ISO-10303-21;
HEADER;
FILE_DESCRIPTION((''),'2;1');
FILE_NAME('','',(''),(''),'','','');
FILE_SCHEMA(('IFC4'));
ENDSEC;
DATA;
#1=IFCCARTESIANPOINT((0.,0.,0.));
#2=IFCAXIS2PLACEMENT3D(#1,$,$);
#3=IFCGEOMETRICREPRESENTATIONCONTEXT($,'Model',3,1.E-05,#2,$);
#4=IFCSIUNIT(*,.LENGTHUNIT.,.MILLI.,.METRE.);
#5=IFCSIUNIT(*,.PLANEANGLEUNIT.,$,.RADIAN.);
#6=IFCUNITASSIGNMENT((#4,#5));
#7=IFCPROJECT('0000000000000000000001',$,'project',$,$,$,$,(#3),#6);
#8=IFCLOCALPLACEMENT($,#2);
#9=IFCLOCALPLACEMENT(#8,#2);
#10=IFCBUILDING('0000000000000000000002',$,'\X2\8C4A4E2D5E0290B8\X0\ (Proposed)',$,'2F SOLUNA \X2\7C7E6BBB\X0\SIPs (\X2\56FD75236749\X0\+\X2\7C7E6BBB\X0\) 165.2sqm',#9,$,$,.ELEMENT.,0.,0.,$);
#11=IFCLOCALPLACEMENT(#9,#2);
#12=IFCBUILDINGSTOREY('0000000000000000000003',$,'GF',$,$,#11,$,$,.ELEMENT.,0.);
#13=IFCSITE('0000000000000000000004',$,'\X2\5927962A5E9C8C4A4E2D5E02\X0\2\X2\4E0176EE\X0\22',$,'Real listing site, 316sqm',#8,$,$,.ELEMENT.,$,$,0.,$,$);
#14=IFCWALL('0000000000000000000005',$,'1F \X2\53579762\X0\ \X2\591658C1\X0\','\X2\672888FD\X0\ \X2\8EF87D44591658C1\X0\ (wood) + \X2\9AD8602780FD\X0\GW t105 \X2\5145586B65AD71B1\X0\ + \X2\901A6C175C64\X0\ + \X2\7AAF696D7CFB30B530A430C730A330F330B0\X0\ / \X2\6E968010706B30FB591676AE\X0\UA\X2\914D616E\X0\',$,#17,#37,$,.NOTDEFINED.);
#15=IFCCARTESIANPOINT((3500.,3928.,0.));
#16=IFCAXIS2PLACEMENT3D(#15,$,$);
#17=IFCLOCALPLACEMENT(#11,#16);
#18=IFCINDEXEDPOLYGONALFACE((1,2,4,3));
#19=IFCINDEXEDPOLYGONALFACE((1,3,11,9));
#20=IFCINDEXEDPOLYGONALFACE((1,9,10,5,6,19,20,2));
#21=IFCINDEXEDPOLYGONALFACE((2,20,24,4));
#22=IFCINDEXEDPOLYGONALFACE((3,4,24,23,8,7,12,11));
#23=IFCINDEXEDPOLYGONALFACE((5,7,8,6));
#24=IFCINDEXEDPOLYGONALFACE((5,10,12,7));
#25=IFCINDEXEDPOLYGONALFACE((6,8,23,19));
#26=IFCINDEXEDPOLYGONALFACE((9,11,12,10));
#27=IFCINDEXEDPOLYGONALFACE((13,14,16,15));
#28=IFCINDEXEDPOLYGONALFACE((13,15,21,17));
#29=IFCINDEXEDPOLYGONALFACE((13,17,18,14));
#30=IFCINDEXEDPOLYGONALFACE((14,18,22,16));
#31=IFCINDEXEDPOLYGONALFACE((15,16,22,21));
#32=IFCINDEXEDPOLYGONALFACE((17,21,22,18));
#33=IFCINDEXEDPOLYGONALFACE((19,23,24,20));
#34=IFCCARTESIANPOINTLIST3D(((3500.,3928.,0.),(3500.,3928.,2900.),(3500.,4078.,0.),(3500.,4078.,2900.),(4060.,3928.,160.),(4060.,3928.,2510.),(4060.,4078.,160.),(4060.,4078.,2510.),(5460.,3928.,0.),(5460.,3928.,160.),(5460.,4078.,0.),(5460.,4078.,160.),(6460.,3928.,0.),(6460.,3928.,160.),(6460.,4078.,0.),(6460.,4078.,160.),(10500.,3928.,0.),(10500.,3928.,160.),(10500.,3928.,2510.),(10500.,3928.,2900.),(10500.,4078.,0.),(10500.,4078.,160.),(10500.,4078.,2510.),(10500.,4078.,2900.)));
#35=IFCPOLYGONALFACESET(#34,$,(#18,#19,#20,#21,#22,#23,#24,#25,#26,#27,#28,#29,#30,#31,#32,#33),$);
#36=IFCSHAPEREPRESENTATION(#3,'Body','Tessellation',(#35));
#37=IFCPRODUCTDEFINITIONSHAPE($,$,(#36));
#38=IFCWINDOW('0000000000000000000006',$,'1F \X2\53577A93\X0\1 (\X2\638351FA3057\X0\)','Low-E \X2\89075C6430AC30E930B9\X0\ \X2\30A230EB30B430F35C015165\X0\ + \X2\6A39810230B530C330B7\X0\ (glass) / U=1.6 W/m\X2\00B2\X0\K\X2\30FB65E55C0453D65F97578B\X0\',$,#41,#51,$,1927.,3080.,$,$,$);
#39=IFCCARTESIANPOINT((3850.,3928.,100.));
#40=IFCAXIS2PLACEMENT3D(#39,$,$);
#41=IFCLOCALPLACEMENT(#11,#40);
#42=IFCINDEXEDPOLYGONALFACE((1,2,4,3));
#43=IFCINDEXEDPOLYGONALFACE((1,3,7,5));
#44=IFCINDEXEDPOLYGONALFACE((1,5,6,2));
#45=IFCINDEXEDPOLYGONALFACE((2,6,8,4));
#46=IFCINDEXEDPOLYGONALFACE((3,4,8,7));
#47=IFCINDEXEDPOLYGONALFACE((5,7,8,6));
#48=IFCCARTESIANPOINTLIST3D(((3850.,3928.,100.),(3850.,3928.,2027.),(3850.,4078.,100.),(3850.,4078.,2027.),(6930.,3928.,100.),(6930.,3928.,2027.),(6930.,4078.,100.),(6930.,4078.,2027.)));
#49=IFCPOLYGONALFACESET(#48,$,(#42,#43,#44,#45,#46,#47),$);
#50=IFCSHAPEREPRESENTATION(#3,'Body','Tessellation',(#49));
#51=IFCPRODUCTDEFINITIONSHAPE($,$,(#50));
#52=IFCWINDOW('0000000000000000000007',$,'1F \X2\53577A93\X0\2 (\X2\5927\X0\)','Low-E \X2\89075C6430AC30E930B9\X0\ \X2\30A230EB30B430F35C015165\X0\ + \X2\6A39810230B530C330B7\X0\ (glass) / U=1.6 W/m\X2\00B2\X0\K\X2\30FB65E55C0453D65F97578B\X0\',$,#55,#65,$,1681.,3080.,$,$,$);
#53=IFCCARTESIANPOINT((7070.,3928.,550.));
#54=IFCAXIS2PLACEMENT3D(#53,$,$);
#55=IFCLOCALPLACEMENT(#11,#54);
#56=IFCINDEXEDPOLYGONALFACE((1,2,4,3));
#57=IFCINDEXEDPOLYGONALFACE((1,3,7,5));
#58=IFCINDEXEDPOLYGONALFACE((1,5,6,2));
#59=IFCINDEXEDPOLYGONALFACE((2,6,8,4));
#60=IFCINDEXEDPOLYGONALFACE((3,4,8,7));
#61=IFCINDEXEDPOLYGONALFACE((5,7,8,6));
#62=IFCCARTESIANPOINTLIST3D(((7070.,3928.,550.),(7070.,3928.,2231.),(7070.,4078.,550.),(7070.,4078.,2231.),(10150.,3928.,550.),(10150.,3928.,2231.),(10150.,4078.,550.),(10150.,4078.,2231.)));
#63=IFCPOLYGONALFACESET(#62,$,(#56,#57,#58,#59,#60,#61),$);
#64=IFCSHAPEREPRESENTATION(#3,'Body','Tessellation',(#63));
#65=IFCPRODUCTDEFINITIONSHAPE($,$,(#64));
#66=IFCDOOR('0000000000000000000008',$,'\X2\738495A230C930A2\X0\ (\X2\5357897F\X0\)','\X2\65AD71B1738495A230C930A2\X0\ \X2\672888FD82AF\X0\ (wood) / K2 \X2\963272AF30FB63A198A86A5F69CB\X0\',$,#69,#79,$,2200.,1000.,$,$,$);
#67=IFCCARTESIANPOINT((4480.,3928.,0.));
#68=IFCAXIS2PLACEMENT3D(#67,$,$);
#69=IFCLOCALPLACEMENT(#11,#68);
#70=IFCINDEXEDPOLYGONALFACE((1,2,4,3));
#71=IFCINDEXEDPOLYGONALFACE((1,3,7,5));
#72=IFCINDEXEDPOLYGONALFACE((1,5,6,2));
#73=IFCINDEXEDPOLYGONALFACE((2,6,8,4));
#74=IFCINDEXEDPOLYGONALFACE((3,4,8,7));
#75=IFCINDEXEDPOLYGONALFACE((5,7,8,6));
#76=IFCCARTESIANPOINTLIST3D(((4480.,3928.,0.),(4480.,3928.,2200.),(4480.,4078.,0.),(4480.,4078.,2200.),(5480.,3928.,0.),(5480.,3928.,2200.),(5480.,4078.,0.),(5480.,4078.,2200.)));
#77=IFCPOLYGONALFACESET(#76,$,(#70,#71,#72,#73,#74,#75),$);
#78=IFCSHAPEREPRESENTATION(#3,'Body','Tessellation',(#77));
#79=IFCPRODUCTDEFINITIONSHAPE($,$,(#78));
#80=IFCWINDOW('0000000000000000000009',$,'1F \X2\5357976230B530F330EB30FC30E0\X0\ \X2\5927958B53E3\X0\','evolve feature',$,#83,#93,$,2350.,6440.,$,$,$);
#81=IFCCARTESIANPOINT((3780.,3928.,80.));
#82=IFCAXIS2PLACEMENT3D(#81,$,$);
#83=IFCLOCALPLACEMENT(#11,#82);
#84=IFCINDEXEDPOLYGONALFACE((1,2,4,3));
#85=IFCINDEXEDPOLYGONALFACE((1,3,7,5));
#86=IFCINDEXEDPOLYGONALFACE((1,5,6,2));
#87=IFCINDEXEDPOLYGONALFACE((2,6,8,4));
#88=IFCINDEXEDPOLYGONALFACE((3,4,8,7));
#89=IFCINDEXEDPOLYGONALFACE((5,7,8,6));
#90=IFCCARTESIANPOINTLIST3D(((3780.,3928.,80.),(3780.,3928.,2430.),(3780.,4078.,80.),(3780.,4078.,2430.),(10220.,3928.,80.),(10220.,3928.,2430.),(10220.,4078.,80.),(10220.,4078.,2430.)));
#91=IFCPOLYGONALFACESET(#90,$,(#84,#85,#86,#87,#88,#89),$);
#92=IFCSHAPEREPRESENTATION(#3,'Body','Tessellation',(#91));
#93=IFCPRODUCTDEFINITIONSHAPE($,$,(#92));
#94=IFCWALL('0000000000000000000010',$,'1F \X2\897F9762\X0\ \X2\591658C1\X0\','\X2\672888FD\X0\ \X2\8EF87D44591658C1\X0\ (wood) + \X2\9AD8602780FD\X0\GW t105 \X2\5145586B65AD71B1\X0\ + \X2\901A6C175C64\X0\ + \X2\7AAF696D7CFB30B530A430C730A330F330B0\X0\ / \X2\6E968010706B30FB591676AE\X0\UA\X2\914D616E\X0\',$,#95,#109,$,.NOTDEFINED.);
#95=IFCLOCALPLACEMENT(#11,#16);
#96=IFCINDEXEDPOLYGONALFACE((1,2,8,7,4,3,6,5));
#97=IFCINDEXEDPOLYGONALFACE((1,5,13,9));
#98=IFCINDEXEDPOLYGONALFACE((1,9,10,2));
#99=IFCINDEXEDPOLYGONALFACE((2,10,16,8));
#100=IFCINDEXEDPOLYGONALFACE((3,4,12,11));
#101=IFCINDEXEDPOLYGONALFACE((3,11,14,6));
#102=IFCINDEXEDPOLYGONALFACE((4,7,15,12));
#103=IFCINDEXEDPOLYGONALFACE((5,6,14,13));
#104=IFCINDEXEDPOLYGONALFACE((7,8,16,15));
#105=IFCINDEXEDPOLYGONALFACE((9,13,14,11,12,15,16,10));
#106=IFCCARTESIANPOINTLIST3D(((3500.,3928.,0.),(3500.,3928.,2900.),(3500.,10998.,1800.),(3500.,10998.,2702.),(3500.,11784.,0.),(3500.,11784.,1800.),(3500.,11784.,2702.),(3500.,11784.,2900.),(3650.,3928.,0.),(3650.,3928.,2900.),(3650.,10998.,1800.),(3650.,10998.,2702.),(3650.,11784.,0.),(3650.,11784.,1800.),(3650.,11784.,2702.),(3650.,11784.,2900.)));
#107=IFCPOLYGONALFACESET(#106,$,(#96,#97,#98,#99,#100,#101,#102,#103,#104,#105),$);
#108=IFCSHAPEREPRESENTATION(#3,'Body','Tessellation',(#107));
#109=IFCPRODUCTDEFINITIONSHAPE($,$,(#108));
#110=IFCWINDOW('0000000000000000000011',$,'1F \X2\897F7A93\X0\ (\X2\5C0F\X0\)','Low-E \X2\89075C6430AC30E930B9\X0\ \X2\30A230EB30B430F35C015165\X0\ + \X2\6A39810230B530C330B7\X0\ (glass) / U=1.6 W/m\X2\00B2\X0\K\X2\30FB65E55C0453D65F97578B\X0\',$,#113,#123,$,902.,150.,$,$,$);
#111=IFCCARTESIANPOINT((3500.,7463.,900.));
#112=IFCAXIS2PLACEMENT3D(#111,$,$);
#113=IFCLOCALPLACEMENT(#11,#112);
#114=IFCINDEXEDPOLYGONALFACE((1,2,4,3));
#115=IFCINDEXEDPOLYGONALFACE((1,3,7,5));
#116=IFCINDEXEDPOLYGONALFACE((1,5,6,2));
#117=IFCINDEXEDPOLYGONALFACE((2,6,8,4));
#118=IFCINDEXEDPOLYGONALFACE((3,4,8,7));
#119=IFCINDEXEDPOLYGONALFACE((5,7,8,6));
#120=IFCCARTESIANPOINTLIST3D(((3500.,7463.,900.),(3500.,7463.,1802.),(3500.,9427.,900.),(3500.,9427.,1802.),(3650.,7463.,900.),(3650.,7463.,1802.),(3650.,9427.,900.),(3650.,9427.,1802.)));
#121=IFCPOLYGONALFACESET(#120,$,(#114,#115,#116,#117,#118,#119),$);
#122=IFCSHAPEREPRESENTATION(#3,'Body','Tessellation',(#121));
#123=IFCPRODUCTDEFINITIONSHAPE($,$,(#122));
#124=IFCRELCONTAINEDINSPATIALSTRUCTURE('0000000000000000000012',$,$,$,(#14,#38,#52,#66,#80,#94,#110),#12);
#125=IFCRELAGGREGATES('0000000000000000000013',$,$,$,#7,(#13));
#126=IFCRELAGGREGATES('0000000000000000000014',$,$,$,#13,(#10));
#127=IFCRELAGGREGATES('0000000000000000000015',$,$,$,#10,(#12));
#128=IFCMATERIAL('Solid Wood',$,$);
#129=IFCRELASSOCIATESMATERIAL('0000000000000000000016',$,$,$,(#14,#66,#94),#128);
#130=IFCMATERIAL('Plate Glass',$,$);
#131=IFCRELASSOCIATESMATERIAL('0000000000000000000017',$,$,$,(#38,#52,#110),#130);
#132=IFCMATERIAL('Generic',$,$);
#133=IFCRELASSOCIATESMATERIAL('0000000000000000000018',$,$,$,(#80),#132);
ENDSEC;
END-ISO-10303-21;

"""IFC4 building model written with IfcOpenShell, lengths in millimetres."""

from ifc_helpers import new_model, si_unit, frame, frame_2d, origin, place, context, project, spatial, rectangle, extrude, material, element, fill, save


model = new_model("IFC4")

# Units and contexts
model_context = context("Model", 3, precision=1e-05, world=origin())
ifc_project = project(units=[si_unit("LENGTHUNIT", "METRE", prefix="MILLI"), si_unit("PLANEANGLEUNIT", "RADIAN")], contexts=[model_context])

# Site, building, storey
site_placement = place(None, origin())
site = spatial("IfcSite", under=ifc_project, at=site_placement, Name="大阪府豊中市2丁目22", ObjectType="Real listing site, 316sqm", CompositionType="ELEMENT", RefElevation=0.0)
building_placement = place(site_placement, origin())
building = spatial("IfcBuilding", under=site, at=building_placement, Name="豊中市邸 (Proposed)", ObjectType="2F SOLUNA 籾殻SIPs (国産杉+籾殻) 165.2sqm", CompositionType="ELEMENT", ElevationOfRefHeight=0.0, ElevationOfTerrain=0.0)
storey_placement = place(building_placement, origin())
storey = spatial("IfcBuildingStorey", under=building, at=storey_placement, Name="GF", CompositionType="ELEMENT", Elevation=0.0)

# Shared definitions
ifc_material_1 = material(Name="Solid Wood")
ifc_material_2 = material(Name="Generic")

# Wall, openings, windows, door
wall_1_placement = place(storey_placement, frame((3500.0, 3928.0, 0.0)))
wall_1 = element("IfcWall", 1, at=wall_1_placement, inside=storey, material=ifc_material_1, Name="1F 南面 外壁", Description="木製 軸組外壁 (wood) + 高性能GW t105 充填断熱 + 通気層 + 窯業系サイディング / 準耐火・外皮UA配慮", PredefinedType="NOTDEFINED", context=model_context, shape_type="SweptSolid", body=[
    extrude(rectangle(XDim=7000.0, YDim=150.0, at=frame_2d((3500.0, 75.0))), frame((3500.0, 3928.0, 0.0)), (0.0, 0.0, 1.0), 2900.0),
])
opening_1_placement = place(storey_placement, frame((3850.0, 3928.0, 100.0)))
opening_1 = element("IfcOpeningElement", 2, at=opening_1_placement, cuts=wall_1, PredefinedType="NOTDEFINED", context=model_context, shape_type="SweptSolid", body=[
    extrude(rectangle(XDim=3080.0, YDim=150.0, at=frame_2d((1540.0, 75.0))), frame((3850.0, 3928.0, 100.0)), (0.0, 0.0, 1.0), 1927.0),
])
opening_2_placement = place(storey_placement, frame((7070.0, 3928.0, 550.0)))
opening_2 = element("IfcOpeningElement", 3, at=opening_2_placement, cuts=wall_1, PredefinedType="NOTDEFINED", context=model_context, shape_type="SweptSolid", body=[
    extrude(rectangle(XDim=3080.0, YDim=150.0, at=frame_2d((1540.0, 75.0))), frame((7070.0, 3928.0, 550.0)), (0.0, 0.0, 1.0), 1681.0),
])
opening_3_placement = place(storey_placement, frame((4480.0, 3928.0, 0.0)))
opening_3 = element("IfcOpeningElement", 4, at=opening_3_placement, cuts=wall_1, PredefinedType="NOTDEFINED", context=model_context, shape_type="SweptSolid", body=[
    extrude(rectangle(XDim=1000.0, YDim=150.0, at=frame_2d((500.0, 75.0))), frame((4480.0, 3928.0, 0.0)), (0.0, 0.0, 1.0), 2200.0),
])
opening_4_placement = place(storey_placement, frame((3780.0, 3928.0, 80.0)))
opening_4 = element("IfcOpeningElement", 5, at=opening_4_placement, cuts=wall_1, PredefinedType="NOTDEFINED", context=model_context, shape_type="SweptSolid", body=[
    extrude(rectangle(XDim=6440.0, YDim=150.0, at=frame_2d((3220.0, 75.0))), frame((3780.0, 3928.0, 80.0)), (0.0, 0.0, 1.0), 2350.0),
])
ifc_material_3 = material(Name="Plate Glass")
window_1_placement = place(storey_placement, frame((3850.0, 3928.0, 100.0)))
window_1 = element("IfcWindow", 6, at=window_1_placement, inside=storey, material=ifc_material_3, Name="1F 南窓1 (掃出し)", Description="Low-E 複層ガラス アルゴン封入 + 樹脂サッシ (glass) / U=1.6 W/m²K・日射取得型", OverallHeight=1927.0, OverallWidth=3080.0, context=model_context, shape_type="SweptSolid", body=[
    extrude(rectangle(XDim=3080.0, YDim=150.0, at=frame_2d((1540.0, 75.0))), frame((3850.0, 3928.0, 100.0)), (0.0, 0.0, 1.0), 1927.0),
])
fill(opening_1, window_1)
window_2_placement = place(storey_placement, frame((7070.0, 3928.0, 550.0)))
window_2 = element("IfcWindow", 7, at=window_2_placement, inside=storey, material=ifc_material_3, Name="1F 南窓2 (大)", Description="Low-E 複層ガラス アルゴン封入 + 樹脂サッシ (glass) / U=1.6 W/m²K・日射取得型", OverallHeight=1681.0, OverallWidth=3080.0, context=model_context, shape_type="SweptSolid", body=[
    extrude(rectangle(XDim=3080.0, YDim=150.0, at=frame_2d((1540.0, 75.0))), frame((7070.0, 3928.0, 550.0)), (0.0, 0.0, 1.0), 1681.0),
])
fill(opening_2, window_2)
door_placement = place(storey_placement, frame((4480.0, 3928.0, 0.0)))
door = element("IfcDoor", 8, at=door_placement, inside=storey, material=ifc_material_1, Name="玄関ドア (南西)", Description="断熱玄関ドア 木製芯 (wood) / K2 防犯・採風機構", OverallHeight=2200.0, OverallWidth=1000.0, context=model_context, shape_type="SweptSolid", body=[
    extrude(rectangle(XDim=1000.0, YDim=150.0, at=frame_2d((500.0, 75.0))), frame((4480.0, 3928.0, 0.0)), (0.0, 0.0, 1.0), 2200.0),
])
fill(opening_3, door)
window_3_placement = place(storey_placement, frame((3780.0, 3928.0, 80.0)))
window_3 = element("IfcWindow", 9, at=window_3_placement, inside=storey, material=ifc_material_2, Name="1F 南面サンルーム 大開口", Description="evolve feature", OverallHeight=2350.0, OverallWidth=6440.0, context=model_context, shape_type="SweptSolid", body=[
    extrude(rectangle(XDim=6440.0, YDim=150.0, at=frame_2d((3220.0, 75.0))), frame((3780.0, 3928.0, 80.0)), (0.0, 0.0, 1.0), 2350.0),
])
fill(opening_4, window_3)

# Wall, opening, window
wall_2_placement = place(storey_placement, frame((3500.0, 3928.0, 0.0)))
wall_2 = element("IfcWall", 10, at=wall_2_placement, inside=storey, material=ifc_material_1, Name="1F 西面 外壁", Description="木製 軸組外壁 (wood) + 高性能GW t105 充填断熱 + 通気層 + 窯業系サイディング / 準耐火・外皮UA配慮", PredefinedType="NOTDEFINED", context=model_context, shape_type="SweptSolid", body=[
    extrude(rectangle(XDim=150.0, YDim=7856.0, at=frame_2d((75.0, 3928.0))), frame((3500.0, 3928.0, 0.0)), (0.0, 0.0, 1.0), 2900.0),
])
opening_5_placement = place(storey_placement, frame((3500.0, 7463.0, 900.0)))
opening_5 = element("IfcOpeningElement", 11, at=opening_5_placement, cuts=wall_2, PredefinedType="NOTDEFINED", context=model_context, shape_type="SweptSolid", body=[
    extrude(rectangle(XDim=150.0, YDim=1964.0, at=frame_2d((75.0, 982.0))), frame((3500.0, 7463.0, 900.0)), (0.0, 0.0, 1.0), 902.0),
])
window_4_placement = place(storey_placement, frame((3500.0, 7463.0, 900.0)))
window_4 = element("IfcWindow", 12, at=window_4_placement, inside=storey, material=ifc_material_3, Name="1F 西窓 (小)", Description="Low-E 複層ガラス アルゴン封入 + 樹脂サッシ (glass) / U=1.6 W/m²K・日射取得型", OverallHeight=902.0, OverallWidth=150.0, context=model_context, shape_type="SweptSolid", body=[
    extrude(rectangle(XDim=150.0, YDim=1964.0, at=frame_2d((75.0, 982.0))), frame((3500.0, 7463.0, 900.0)), (0.0, 0.0, 1.0), 902.0),
])
fill(opening_5, window_4)

save(model, "model.ifc")
